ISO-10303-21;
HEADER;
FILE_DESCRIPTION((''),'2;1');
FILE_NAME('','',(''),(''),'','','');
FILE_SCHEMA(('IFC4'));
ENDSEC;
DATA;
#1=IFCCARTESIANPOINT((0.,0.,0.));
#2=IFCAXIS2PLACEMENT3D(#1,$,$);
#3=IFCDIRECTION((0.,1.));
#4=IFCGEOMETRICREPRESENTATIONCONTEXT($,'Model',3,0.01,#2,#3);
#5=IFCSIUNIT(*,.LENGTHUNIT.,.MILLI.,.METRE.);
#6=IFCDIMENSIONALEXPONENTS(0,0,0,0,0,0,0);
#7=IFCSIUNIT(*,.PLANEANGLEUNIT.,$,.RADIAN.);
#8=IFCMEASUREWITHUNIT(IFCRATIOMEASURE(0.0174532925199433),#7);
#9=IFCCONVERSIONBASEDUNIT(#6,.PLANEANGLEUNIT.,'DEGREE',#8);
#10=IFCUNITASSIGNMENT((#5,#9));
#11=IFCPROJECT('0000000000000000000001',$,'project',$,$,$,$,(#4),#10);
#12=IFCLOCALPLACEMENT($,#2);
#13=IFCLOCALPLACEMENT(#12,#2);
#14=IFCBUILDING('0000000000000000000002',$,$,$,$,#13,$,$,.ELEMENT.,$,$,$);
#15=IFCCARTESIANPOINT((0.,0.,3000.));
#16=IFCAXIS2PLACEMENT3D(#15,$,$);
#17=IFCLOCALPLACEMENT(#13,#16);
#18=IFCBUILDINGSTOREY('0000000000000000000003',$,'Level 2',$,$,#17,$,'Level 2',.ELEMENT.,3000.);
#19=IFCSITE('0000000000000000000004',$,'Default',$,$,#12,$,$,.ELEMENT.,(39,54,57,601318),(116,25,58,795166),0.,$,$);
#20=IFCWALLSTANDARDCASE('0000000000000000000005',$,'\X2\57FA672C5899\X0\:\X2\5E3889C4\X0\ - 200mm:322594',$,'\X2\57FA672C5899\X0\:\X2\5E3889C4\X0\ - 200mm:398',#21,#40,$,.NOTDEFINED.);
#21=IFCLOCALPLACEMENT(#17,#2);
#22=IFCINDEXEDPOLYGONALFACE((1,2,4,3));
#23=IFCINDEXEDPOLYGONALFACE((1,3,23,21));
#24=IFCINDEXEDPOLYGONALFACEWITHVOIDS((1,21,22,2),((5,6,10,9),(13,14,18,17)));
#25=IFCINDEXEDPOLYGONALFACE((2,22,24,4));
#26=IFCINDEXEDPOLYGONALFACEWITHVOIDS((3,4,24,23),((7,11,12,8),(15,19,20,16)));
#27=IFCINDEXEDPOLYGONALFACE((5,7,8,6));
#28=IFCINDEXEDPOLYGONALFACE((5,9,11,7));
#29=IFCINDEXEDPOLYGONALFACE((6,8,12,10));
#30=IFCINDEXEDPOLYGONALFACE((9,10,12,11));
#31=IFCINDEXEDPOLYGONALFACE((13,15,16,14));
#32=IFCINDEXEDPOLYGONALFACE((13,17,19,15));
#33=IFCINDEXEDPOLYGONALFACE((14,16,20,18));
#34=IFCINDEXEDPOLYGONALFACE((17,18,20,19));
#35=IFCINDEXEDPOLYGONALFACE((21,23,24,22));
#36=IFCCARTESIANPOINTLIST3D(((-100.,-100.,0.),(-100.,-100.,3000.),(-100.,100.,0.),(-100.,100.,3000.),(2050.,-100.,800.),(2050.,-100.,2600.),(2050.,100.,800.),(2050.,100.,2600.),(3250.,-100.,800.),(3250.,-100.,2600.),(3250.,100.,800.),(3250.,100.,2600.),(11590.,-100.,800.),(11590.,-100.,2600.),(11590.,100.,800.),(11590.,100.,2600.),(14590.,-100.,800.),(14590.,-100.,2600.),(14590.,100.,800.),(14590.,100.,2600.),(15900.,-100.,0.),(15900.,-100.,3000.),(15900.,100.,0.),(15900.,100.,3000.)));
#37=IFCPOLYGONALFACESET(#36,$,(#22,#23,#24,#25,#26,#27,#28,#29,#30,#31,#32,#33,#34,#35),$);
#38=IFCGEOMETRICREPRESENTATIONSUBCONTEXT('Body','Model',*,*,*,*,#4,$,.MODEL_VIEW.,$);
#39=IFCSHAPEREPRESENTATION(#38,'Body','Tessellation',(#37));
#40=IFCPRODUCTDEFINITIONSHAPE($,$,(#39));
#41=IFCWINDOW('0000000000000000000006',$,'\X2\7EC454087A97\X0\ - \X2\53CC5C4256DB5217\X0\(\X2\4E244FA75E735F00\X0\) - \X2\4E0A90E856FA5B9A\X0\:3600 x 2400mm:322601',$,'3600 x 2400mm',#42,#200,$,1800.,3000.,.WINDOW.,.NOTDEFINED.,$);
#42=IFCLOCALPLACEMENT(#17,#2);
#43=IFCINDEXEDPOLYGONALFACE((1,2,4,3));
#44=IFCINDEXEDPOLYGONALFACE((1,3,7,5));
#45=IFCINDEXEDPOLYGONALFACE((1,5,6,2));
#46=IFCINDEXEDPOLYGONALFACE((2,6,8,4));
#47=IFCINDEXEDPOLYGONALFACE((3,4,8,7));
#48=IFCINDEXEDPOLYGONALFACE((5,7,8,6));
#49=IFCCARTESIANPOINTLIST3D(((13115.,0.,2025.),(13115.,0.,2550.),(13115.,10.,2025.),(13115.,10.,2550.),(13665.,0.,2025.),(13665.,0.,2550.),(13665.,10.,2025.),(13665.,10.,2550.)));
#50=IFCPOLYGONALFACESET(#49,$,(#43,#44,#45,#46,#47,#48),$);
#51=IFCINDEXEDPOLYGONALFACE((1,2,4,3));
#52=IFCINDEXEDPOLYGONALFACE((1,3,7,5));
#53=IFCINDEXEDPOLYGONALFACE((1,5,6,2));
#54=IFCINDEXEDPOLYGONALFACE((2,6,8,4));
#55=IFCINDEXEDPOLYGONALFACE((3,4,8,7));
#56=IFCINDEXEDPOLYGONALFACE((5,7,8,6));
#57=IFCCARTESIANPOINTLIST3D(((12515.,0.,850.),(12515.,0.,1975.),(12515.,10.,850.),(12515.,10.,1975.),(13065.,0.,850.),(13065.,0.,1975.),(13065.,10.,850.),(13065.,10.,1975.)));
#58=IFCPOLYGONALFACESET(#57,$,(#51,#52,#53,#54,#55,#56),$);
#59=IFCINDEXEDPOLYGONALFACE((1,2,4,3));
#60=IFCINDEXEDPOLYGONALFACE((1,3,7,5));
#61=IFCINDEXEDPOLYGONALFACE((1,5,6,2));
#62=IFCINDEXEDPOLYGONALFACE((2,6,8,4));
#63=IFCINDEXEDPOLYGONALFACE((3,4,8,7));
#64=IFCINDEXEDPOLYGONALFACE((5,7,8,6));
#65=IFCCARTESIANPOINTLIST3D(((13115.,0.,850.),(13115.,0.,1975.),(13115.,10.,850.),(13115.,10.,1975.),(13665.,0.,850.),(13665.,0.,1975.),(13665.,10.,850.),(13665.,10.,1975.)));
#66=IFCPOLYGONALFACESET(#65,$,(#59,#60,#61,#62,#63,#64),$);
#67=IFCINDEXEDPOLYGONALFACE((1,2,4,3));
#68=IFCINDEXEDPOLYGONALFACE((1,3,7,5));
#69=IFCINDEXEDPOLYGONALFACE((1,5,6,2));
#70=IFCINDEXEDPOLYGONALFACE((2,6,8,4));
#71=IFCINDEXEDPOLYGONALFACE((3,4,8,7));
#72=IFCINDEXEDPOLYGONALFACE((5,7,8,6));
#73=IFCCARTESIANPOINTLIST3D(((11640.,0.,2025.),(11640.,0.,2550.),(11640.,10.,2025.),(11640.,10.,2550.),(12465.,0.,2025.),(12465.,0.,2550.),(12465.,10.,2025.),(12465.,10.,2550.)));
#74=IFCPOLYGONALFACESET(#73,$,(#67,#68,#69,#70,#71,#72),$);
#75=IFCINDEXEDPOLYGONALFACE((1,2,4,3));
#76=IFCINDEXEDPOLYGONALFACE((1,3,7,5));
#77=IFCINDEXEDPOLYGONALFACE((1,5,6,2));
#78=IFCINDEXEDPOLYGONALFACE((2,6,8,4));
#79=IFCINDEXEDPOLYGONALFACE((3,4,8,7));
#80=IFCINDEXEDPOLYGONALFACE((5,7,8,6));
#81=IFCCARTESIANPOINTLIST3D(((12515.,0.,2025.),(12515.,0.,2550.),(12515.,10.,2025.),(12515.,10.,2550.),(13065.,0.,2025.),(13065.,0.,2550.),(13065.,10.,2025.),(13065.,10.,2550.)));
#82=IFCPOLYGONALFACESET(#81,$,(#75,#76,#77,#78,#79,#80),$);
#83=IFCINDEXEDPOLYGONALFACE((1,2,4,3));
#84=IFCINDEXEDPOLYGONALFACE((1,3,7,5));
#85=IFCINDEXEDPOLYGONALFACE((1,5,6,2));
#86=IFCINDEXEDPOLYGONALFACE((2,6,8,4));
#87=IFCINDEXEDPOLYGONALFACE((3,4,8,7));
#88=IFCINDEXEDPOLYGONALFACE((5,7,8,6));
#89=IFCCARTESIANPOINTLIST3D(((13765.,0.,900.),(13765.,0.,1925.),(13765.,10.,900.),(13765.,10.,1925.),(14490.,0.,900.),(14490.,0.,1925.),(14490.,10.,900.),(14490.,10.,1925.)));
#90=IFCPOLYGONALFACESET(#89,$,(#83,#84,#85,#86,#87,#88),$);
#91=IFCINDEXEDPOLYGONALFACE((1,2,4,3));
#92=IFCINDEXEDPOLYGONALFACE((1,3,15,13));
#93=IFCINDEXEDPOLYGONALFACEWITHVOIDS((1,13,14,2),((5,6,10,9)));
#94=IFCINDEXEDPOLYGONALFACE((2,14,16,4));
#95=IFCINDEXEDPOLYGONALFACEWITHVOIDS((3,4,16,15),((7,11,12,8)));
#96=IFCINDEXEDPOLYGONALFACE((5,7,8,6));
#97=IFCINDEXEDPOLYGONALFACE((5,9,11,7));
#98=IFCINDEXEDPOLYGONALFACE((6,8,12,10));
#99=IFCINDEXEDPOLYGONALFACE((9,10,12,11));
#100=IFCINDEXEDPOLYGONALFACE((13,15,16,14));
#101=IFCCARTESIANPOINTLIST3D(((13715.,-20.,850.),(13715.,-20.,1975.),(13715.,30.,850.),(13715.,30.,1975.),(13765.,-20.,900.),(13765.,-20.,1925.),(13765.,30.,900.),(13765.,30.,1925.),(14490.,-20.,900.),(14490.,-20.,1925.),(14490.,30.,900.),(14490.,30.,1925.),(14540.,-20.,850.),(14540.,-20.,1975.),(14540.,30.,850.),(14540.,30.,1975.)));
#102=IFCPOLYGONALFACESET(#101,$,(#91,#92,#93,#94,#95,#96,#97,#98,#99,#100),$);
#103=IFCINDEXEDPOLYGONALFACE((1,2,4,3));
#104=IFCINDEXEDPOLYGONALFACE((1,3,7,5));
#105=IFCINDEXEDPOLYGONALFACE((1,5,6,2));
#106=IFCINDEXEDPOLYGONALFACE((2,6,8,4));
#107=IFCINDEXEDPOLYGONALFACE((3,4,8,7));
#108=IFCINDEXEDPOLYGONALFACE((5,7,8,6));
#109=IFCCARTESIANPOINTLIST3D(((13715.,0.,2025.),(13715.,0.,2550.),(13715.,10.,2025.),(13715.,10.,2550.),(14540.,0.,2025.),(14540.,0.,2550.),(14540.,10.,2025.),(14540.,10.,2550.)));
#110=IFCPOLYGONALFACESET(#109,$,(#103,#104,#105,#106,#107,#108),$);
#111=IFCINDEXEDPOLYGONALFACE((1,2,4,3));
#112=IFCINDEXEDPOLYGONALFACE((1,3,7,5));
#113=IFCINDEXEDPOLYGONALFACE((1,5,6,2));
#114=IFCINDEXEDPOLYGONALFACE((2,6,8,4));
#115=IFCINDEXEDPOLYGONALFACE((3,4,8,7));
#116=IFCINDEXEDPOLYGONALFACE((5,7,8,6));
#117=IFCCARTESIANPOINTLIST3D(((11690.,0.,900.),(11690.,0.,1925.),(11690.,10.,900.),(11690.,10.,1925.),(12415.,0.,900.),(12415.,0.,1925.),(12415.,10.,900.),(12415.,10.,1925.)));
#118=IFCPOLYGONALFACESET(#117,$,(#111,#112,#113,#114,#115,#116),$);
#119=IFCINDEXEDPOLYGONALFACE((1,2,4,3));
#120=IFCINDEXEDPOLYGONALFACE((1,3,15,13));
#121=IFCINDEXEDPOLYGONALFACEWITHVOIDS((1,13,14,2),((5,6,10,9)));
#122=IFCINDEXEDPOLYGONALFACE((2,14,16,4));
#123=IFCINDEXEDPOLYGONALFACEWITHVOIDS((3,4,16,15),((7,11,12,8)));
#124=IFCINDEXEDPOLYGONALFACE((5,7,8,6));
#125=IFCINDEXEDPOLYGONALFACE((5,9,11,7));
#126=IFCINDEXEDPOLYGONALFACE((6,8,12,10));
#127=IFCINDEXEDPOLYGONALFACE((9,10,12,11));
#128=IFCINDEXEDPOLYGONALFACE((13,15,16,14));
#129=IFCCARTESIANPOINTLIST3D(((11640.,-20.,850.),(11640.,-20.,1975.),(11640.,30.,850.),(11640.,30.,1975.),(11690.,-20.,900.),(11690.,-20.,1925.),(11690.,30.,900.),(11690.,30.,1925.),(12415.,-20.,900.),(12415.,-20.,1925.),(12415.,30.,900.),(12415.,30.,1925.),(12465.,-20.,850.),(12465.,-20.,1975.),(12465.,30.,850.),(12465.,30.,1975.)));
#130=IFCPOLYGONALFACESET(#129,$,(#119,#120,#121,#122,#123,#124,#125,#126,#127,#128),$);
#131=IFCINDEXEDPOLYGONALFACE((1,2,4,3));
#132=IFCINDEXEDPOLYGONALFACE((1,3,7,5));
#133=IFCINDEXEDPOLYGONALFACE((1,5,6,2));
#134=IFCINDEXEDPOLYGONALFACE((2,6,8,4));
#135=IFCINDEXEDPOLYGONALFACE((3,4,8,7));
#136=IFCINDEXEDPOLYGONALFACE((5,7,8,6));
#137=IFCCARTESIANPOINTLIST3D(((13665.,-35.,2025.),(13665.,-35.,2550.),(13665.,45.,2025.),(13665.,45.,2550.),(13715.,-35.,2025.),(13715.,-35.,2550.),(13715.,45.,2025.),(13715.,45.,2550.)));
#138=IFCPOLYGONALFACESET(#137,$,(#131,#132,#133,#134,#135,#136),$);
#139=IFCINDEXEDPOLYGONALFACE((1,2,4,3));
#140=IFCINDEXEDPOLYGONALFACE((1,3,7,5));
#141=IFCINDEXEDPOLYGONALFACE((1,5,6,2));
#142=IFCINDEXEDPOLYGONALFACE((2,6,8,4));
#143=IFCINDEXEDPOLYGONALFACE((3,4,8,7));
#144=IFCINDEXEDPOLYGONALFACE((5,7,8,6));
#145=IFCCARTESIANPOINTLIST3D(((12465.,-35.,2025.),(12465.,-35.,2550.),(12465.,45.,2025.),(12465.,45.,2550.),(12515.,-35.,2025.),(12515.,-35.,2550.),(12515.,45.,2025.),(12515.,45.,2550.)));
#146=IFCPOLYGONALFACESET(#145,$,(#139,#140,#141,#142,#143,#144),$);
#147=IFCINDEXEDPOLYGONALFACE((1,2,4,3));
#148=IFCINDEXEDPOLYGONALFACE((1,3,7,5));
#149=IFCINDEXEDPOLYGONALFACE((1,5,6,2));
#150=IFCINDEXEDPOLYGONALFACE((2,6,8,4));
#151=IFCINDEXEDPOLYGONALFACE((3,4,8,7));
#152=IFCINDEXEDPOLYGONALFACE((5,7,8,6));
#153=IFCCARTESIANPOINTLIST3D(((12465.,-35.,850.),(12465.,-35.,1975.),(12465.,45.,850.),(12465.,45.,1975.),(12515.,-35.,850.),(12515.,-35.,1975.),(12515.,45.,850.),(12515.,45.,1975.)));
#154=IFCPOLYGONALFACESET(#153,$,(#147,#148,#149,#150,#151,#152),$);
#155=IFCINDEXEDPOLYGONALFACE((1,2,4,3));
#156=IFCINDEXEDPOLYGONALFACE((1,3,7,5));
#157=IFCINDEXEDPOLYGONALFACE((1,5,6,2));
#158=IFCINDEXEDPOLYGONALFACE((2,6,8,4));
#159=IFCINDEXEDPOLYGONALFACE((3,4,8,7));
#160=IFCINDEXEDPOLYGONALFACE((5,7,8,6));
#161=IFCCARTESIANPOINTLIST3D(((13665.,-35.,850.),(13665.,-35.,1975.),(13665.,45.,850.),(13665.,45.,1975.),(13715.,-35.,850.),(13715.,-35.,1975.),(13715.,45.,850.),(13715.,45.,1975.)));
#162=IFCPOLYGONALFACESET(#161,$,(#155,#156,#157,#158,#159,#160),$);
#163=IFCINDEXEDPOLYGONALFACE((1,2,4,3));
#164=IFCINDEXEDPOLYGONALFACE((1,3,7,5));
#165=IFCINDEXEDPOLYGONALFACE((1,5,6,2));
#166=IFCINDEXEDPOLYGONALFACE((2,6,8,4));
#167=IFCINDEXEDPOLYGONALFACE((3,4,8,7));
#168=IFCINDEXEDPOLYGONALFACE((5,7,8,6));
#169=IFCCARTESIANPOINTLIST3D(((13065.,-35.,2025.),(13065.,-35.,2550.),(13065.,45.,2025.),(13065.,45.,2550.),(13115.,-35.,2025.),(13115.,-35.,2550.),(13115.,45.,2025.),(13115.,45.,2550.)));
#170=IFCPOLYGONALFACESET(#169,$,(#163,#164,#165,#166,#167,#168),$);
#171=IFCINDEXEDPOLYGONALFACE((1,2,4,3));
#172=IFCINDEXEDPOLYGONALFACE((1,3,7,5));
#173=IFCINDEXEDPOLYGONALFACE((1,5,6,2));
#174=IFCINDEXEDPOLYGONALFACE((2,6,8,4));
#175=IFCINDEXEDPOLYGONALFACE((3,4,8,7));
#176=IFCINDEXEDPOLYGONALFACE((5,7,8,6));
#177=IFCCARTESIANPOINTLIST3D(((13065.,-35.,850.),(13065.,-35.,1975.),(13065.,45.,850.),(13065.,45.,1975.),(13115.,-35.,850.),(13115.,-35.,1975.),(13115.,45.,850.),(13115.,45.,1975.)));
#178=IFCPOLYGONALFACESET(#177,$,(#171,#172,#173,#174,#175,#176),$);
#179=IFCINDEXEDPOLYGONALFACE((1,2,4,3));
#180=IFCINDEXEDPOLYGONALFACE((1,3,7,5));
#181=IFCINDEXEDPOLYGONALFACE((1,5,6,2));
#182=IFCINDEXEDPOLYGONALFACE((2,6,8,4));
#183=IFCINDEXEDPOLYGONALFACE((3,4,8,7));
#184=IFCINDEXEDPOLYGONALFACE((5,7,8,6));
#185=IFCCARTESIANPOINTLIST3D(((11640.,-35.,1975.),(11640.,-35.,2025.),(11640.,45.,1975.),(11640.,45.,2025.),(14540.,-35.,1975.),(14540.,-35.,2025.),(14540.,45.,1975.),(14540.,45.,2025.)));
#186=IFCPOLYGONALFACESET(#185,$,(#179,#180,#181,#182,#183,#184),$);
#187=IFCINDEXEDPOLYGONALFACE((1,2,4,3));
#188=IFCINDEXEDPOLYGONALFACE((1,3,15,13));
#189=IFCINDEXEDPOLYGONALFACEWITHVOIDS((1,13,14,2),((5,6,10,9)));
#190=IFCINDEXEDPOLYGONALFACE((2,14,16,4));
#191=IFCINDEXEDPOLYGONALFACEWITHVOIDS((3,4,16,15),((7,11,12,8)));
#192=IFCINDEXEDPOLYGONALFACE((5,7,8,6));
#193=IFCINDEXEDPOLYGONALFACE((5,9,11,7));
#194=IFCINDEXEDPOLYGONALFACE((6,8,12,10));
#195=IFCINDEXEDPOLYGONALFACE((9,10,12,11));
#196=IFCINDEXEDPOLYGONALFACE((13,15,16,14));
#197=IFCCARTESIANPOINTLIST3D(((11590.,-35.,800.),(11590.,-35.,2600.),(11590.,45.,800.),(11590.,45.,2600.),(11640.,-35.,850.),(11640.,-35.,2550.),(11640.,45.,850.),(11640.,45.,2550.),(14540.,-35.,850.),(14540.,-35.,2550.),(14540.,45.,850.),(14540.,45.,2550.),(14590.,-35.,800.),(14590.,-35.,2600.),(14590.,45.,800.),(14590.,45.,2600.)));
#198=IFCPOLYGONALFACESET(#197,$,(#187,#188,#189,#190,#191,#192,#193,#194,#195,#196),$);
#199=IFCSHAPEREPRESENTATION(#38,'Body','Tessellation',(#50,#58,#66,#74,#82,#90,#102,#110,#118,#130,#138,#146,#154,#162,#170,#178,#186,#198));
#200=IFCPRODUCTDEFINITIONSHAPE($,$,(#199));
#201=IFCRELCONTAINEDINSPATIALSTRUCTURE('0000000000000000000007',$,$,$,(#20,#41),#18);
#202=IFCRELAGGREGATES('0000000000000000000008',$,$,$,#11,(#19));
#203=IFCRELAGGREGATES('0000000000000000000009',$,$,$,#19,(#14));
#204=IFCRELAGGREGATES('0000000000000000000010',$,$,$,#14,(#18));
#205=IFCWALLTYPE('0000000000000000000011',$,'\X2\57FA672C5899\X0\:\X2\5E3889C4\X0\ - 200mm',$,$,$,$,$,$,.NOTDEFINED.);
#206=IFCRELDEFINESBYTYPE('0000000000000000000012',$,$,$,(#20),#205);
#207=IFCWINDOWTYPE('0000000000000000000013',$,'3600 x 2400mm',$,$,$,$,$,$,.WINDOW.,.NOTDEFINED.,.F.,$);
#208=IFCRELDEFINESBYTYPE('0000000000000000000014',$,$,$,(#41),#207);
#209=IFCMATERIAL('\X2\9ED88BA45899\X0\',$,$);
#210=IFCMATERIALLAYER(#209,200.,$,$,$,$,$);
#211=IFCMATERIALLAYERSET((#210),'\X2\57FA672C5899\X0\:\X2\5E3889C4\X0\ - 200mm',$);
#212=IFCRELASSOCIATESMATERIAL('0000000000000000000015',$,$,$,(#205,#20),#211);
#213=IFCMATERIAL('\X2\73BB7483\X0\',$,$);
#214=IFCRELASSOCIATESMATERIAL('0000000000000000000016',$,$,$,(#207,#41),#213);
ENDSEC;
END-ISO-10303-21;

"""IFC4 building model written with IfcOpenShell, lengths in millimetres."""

from ifc_helpers import new_model, entity, si_unit, converted_unit, direction, frame, frame_2d, origin, origin_2d_with_axis, place, context, subcontext, project, spatial, polyline, rectangle, outline, extrude, source, transform, mapped, material, layer, layer_set, layer_usage, type_object, type_shapes, element, fill, save


model = new_model("IFC4")

# Units and contexts
model_context = context("Model", 3, precision=0.01, world=origin(), true_north=direction((0.0, 1.0)))
body_context = subcontext(model_context, "Body", "Model", "MODEL_VIEW")
ifc_project = project(units=[si_unit("LENGTHUNIT", "METRE", prefix="MILLI"), converted_unit("PLANEANGLEUNIT", "DEGREE", entity("IfcRatioMeasure", 0.0174532925199433), si_unit("PLANEANGLEUNIT", "RADIAN"), dimensions=[0, 0, 0, 0, 0, 0, 0])], contexts=[model_context])

# Site, building, storey
site_placement = place(None, origin())
site = spatial("IfcSite", under=ifc_project, at=site_placement, Name="Default", CompositionType="ELEMENT", RefLatitude=(39, 54, 57, 601318), RefLongitude=(116, 25, 58, 795166), RefElevation=0.0)
building_placement = place(site_placement, origin())
building = spatial("IfcBuilding", under=site, at=building_placement, CompositionType="ELEMENT")
storey_placement = place(building_placement, frame((0.0, 0.0, 3000.0)))
storey = spatial("IfcBuildingStorey", under=building, at=storey_placement, Name="Level 2", LongName="Level 2", CompositionType="ELEMENT", Elevation=3000.0)

# Shared definitions
ifc_material_1 = material(Name="默认墙")
ifc_layer_1 = layer(ifc_material_1, 200.0)
ifc_layer_set_1 = layer_set([ifc_layer_1], Name="基本墙:常规 - 200mm")
wall_type = type_object("IfcWallType", Name="基本墙:常规 - 200mm", PredefinedType="NOTDEFINED", material=ifc_layer_set_1)

# Shared definitions
ifc_material_2 = material(Name="玻璃")

# Wall, openings, window
ifc_layer_usage_1 = layer_usage(ifc_layer_set_1, "AXIS2", "NEGATIVE", 100.0)
wall_1_placement = place(storey_placement, frame((15900.0, 0.0, 0.0), z_axis=(0.0, 0.0, 1.0), x_axis=(-1.0, 0.0, 0.0)))
wall_1 = element("IfcWallStandardCase", 1, at=wall_1_placement, inside=storey, type_object=wall_type, material=ifc_layer_usage_1, Name="基本墙:常规 - 200mm:322594", ObjectType="基本墙:常规 - 200mm:398", PredefinedType="NOTDEFINED", context=body_context, shape_type="SweptSolid", body=[
    extrude(rectangle(XDim=16000.0, YDim=200.0, at=frame_2d((8000.0, 0.0), x_axis=(-1.0, 0.0))), origin(), (0.0, 0.0, 1.0), 3000.0),
])
opening_1_placement = place(wall_1_placement, frame((12650.0, -100.0, 800.0)))
element("IfcOpeningElement", 2, at=opening_1_placement, cuts=wall_1, ObjectType="Opening", PredefinedType="OPENING", context=body_context, shape_type="SweptSolid", body=[
    extrude(rectangle(XDim=1800.0, YDim=1200.0, at=frame_2d((900.0, 600.0), x_axis=(1.0, 0.0))), frame((0.0, 0.0, 0.0), z_axis=(0.0, 1.0, 0.0), x_axis=(0.0, 0.0, 1.0)), (0.0, 0.0, 1.0), 200.0),
])
opening_2_placement = place(wall_1_placement, frame((1310.0, -100.0, 800.0)))
opening_2 = element("IfcOpeningElement", 3, at=opening_2_placement, cuts=wall_1, ObjectType="Opening", PredefinedType="OPENING", context=body_context, shape_type="SweptSolid", body=[
    extrude(rectangle(XDim=1800.0, YDim=3000.0, at=frame_2d((900.0, 1500.0), x_axis=(1.0, 0.0))), frame((0.0, 0.0, 0.0), z_axis=(0.0, 1.0, 0.0), x_axis=(0.0, 0.0, 1.0)), (0.0, 0.0, 1.0), 200.0),
])
window_type_1 = type_object("IfcWindowType", Name="3600 x 2400mm", ParameterTakesPrecedence=False, PartitioningType="NOTDEFINED", PredefinedType="WINDOW", material=ifc_material_2)
shared_shape_1 = source(origin(), body_context, "Body", "SweptSolid", [
    extrude(rectangle(XDim=10.0, YDim=550.0, at=origin_2d_with_axis()), frame((1200.0, 95.0, 1225.0), z_axis=(0.0, 0.0, 1.0), x_axis=(0.0, 1.0, 0.0)), (0.0, 0.0, 1.0), 525.0),
    extrude(rectangle(XDim=10.0, YDim=550.0, at=origin_2d_with_axis()), frame((1800.0, 95.0, 50.0), z_axis=(0.0, 0.0, 1.0), x_axis=(0.0, 1.0, 0.0)), (0.0, 0.0, 1.0), 1125.0),
    extrude(rectangle(XDim=10.0, YDim=550.0, at=origin_2d_with_axis()), frame((1200.0, 95.0, 50.0), z_axis=(0.0, 0.0, 1.0), x_axis=(0.0, 1.0, 0.0)), (0.0, 0.0, 1.0), 1125.0),
    extrude(rectangle(XDim=10.0, YDim=825.0, at=origin_2d_with_axis()), frame((2537.5, 95.0, 1225.0), z_axis=(0.0, 0.0, 1.0), x_axis=(0.0, 1.0, 0.0)), (0.0, 0.0, 1.0), 525.0),
    extrude(rectangle(XDim=10.0, YDim=550.0, at=origin_2d_with_axis()), frame((1800.0, 95.0, 1225.0), z_axis=(0.0, 0.0, 1.0), x_axis=(0.0, 1.0, 0.0)), (0.0, 0.0, 1.0), 525.0),
    extrude(rectangle(XDim=10.0, YDim=725.0, at=origin_2d_with_axis()), frame((462.5, 95.0, 100.0), z_axis=(0.0, 0.0, 1.0), x_axis=(0.0, 1.0, 0.0)), (0.0, 0.0, 1.0), 1025.0),
    extrude(outline(polyline([(-562.5, -412.5), (562.5, -412.5), (562.5, 412.5), (-562.5, 412.5), (-562.5, -412.5)]), holes=[polyline([(512.5, -362.5), (-512.5, -362.5), (-512.5, 362.5), (512.5, 362.5), (512.5, -362.5)])]), frame((462.5, 70.0, 612.5), z_axis=(0.0, 1.0, 0.0), x_axis=(0.0, 0.0, -1.0)), (0.0, 0.0, 1.0), 50.0),
    extrude(rectangle(XDim=10.0, YDim=825.0, at=origin_2d_with_axis()), frame((462.5, 95.0, 1225.0), z_axis=(0.0, 0.0, 1.0), x_axis=(0.0, 1.0, 0.0)), (0.0, 0.0, 1.0), 525.0),
    extrude(rectangle(XDim=10.0, YDim=725.0, at=origin_2d_with_axis()), frame((2537.5, 95.0, 100.0), z_axis=(0.0, 0.0, 1.0), x_axis=(0.0, 1.0, 0.0)), (0.0, 0.0, 1.0), 1025.0),
    extrude(outline(polyline([(-562.5, -412.5), (562.5, -412.5), (562.5, 412.5), (-562.5, 412.5), (-562.5, -412.5)]), holes=[polyline([(512.5, -362.5), (-512.5, -362.5), (-512.5, 362.5), (512.5, 362.5), (512.5, -362.5)])]), frame((2537.5, 70.0, 612.5), z_axis=(0.0, 1.0, 0.0), x_axis=(0.0, 0.0, -1.0)), (0.0, 0.0, 1.0), 50.0),
    extrude(rectangle(XDim=80.0, YDim=50.0, at=origin_2d_with_axis()), frame((900.0, 95.0, 1225.0), z_axis=(0.0, 0.0, 1.0), x_axis=(0.0, -1.0, 0.0)), (0.0, 0.0, 1.0), 525.0),
    extrude(rectangle(XDim=80.0, YDim=50.0, at=origin_2d_with_axis()), frame((2100.0, 95.0, 1225.0), z_axis=(0.0, 0.0, 1.0), x_axis=(0.0, -1.0, 0.0)), (0.0, 0.0, 1.0), 525.0),
    extrude(rectangle(XDim=80.0, YDim=50.0, at=origin_2d_with_axis()), frame((2100.0, 95.0, 50.0), z_axis=(0.0, 0.0, 1.0), x_axis=(0.0, -1.0, 0.0)), (0.0, 0.0, 1.0), 1125.0),
    extrude(rectangle(XDim=80.0, YDim=50.0, at=origin_2d_with_axis()), frame((900.0, 95.0, 50.0), z_axis=(0.0, 0.0, 1.0), x_axis=(0.0, -1.0, 0.0)), (0.0, 0.0, 1.0), 1125.0),
    extrude(rectangle(XDim=80.0, YDim=50.0, at=origin_2d_with_axis()), frame((1500.0, 95.0, 1225.0), z_axis=(0.0, 0.0, 1.0), x_axis=(0.0, -1.0, 0.0)), (0.0, 0.0, 1.0), 525.0),
    extrude(rectangle(XDim=80.0, YDim=50.0, at=origin_2d_with_axis()), frame((1500.0, 95.0, 50.0), z_axis=(0.0, 0.0, 1.0), x_axis=(0.0, -1.0, 0.0)), (0.0, 0.0, 1.0), 1125.0),
    extrude(rectangle(XDim=80.0, YDim=2900.0, at=origin_2d_with_axis()), frame((1500.0, 95.0, 1175.0), z_axis=(0.0, 0.0, 1.0), x_axis=(0.0, -1.0, 0.0)), (0.0, 0.0, 1.0), 50.0),
    extrude(outline(polyline([(-1500.0, -900.0), (1500.0, -900.0), (1500.0, 900.0), (-1500.0, 900.0), (-1500.0, -900.0)]), holes=[polyline([(1450.0, -850.0), (-1450.0, -850.0), (-1450.0, 850.0), (1450.0, 850.0), (1450.0, -850.0)])]), frame((1500.0, 55.0, 900.0), z_axis=(0.0, 1.0, 0.0), x_axis=(1.0, 0.0, 0.0)), (0.0, 0.0, 1.0), 80.0),
])
type_shapes(window_type_1, [shared_shape_1])
window_1_placement = place(opening_2_placement, origin())
window_1 = element("IfcWindow", 4, at=window_1_placement, inside=storey, type_object=window_type_1, material=ifc_material_2, Name="组合窗 - 双层四列(两侧平开) - 上部固定:3600 x 2400mm:322601", ObjectType="3600 x 2400mm", OverallHeight=1800.0, OverallWidth=3000.0, PartitioningType="NOTDEFINED", PredefinedType="WINDOW", context=body_context, shape_type="MappedRepresentation", body=[
    mapped(shared_shape_1, transform((0.0, 0.0, 0.0), scale=1.0)),
])
fill(opening_2, window_1)

save(model, "model.ifc")
